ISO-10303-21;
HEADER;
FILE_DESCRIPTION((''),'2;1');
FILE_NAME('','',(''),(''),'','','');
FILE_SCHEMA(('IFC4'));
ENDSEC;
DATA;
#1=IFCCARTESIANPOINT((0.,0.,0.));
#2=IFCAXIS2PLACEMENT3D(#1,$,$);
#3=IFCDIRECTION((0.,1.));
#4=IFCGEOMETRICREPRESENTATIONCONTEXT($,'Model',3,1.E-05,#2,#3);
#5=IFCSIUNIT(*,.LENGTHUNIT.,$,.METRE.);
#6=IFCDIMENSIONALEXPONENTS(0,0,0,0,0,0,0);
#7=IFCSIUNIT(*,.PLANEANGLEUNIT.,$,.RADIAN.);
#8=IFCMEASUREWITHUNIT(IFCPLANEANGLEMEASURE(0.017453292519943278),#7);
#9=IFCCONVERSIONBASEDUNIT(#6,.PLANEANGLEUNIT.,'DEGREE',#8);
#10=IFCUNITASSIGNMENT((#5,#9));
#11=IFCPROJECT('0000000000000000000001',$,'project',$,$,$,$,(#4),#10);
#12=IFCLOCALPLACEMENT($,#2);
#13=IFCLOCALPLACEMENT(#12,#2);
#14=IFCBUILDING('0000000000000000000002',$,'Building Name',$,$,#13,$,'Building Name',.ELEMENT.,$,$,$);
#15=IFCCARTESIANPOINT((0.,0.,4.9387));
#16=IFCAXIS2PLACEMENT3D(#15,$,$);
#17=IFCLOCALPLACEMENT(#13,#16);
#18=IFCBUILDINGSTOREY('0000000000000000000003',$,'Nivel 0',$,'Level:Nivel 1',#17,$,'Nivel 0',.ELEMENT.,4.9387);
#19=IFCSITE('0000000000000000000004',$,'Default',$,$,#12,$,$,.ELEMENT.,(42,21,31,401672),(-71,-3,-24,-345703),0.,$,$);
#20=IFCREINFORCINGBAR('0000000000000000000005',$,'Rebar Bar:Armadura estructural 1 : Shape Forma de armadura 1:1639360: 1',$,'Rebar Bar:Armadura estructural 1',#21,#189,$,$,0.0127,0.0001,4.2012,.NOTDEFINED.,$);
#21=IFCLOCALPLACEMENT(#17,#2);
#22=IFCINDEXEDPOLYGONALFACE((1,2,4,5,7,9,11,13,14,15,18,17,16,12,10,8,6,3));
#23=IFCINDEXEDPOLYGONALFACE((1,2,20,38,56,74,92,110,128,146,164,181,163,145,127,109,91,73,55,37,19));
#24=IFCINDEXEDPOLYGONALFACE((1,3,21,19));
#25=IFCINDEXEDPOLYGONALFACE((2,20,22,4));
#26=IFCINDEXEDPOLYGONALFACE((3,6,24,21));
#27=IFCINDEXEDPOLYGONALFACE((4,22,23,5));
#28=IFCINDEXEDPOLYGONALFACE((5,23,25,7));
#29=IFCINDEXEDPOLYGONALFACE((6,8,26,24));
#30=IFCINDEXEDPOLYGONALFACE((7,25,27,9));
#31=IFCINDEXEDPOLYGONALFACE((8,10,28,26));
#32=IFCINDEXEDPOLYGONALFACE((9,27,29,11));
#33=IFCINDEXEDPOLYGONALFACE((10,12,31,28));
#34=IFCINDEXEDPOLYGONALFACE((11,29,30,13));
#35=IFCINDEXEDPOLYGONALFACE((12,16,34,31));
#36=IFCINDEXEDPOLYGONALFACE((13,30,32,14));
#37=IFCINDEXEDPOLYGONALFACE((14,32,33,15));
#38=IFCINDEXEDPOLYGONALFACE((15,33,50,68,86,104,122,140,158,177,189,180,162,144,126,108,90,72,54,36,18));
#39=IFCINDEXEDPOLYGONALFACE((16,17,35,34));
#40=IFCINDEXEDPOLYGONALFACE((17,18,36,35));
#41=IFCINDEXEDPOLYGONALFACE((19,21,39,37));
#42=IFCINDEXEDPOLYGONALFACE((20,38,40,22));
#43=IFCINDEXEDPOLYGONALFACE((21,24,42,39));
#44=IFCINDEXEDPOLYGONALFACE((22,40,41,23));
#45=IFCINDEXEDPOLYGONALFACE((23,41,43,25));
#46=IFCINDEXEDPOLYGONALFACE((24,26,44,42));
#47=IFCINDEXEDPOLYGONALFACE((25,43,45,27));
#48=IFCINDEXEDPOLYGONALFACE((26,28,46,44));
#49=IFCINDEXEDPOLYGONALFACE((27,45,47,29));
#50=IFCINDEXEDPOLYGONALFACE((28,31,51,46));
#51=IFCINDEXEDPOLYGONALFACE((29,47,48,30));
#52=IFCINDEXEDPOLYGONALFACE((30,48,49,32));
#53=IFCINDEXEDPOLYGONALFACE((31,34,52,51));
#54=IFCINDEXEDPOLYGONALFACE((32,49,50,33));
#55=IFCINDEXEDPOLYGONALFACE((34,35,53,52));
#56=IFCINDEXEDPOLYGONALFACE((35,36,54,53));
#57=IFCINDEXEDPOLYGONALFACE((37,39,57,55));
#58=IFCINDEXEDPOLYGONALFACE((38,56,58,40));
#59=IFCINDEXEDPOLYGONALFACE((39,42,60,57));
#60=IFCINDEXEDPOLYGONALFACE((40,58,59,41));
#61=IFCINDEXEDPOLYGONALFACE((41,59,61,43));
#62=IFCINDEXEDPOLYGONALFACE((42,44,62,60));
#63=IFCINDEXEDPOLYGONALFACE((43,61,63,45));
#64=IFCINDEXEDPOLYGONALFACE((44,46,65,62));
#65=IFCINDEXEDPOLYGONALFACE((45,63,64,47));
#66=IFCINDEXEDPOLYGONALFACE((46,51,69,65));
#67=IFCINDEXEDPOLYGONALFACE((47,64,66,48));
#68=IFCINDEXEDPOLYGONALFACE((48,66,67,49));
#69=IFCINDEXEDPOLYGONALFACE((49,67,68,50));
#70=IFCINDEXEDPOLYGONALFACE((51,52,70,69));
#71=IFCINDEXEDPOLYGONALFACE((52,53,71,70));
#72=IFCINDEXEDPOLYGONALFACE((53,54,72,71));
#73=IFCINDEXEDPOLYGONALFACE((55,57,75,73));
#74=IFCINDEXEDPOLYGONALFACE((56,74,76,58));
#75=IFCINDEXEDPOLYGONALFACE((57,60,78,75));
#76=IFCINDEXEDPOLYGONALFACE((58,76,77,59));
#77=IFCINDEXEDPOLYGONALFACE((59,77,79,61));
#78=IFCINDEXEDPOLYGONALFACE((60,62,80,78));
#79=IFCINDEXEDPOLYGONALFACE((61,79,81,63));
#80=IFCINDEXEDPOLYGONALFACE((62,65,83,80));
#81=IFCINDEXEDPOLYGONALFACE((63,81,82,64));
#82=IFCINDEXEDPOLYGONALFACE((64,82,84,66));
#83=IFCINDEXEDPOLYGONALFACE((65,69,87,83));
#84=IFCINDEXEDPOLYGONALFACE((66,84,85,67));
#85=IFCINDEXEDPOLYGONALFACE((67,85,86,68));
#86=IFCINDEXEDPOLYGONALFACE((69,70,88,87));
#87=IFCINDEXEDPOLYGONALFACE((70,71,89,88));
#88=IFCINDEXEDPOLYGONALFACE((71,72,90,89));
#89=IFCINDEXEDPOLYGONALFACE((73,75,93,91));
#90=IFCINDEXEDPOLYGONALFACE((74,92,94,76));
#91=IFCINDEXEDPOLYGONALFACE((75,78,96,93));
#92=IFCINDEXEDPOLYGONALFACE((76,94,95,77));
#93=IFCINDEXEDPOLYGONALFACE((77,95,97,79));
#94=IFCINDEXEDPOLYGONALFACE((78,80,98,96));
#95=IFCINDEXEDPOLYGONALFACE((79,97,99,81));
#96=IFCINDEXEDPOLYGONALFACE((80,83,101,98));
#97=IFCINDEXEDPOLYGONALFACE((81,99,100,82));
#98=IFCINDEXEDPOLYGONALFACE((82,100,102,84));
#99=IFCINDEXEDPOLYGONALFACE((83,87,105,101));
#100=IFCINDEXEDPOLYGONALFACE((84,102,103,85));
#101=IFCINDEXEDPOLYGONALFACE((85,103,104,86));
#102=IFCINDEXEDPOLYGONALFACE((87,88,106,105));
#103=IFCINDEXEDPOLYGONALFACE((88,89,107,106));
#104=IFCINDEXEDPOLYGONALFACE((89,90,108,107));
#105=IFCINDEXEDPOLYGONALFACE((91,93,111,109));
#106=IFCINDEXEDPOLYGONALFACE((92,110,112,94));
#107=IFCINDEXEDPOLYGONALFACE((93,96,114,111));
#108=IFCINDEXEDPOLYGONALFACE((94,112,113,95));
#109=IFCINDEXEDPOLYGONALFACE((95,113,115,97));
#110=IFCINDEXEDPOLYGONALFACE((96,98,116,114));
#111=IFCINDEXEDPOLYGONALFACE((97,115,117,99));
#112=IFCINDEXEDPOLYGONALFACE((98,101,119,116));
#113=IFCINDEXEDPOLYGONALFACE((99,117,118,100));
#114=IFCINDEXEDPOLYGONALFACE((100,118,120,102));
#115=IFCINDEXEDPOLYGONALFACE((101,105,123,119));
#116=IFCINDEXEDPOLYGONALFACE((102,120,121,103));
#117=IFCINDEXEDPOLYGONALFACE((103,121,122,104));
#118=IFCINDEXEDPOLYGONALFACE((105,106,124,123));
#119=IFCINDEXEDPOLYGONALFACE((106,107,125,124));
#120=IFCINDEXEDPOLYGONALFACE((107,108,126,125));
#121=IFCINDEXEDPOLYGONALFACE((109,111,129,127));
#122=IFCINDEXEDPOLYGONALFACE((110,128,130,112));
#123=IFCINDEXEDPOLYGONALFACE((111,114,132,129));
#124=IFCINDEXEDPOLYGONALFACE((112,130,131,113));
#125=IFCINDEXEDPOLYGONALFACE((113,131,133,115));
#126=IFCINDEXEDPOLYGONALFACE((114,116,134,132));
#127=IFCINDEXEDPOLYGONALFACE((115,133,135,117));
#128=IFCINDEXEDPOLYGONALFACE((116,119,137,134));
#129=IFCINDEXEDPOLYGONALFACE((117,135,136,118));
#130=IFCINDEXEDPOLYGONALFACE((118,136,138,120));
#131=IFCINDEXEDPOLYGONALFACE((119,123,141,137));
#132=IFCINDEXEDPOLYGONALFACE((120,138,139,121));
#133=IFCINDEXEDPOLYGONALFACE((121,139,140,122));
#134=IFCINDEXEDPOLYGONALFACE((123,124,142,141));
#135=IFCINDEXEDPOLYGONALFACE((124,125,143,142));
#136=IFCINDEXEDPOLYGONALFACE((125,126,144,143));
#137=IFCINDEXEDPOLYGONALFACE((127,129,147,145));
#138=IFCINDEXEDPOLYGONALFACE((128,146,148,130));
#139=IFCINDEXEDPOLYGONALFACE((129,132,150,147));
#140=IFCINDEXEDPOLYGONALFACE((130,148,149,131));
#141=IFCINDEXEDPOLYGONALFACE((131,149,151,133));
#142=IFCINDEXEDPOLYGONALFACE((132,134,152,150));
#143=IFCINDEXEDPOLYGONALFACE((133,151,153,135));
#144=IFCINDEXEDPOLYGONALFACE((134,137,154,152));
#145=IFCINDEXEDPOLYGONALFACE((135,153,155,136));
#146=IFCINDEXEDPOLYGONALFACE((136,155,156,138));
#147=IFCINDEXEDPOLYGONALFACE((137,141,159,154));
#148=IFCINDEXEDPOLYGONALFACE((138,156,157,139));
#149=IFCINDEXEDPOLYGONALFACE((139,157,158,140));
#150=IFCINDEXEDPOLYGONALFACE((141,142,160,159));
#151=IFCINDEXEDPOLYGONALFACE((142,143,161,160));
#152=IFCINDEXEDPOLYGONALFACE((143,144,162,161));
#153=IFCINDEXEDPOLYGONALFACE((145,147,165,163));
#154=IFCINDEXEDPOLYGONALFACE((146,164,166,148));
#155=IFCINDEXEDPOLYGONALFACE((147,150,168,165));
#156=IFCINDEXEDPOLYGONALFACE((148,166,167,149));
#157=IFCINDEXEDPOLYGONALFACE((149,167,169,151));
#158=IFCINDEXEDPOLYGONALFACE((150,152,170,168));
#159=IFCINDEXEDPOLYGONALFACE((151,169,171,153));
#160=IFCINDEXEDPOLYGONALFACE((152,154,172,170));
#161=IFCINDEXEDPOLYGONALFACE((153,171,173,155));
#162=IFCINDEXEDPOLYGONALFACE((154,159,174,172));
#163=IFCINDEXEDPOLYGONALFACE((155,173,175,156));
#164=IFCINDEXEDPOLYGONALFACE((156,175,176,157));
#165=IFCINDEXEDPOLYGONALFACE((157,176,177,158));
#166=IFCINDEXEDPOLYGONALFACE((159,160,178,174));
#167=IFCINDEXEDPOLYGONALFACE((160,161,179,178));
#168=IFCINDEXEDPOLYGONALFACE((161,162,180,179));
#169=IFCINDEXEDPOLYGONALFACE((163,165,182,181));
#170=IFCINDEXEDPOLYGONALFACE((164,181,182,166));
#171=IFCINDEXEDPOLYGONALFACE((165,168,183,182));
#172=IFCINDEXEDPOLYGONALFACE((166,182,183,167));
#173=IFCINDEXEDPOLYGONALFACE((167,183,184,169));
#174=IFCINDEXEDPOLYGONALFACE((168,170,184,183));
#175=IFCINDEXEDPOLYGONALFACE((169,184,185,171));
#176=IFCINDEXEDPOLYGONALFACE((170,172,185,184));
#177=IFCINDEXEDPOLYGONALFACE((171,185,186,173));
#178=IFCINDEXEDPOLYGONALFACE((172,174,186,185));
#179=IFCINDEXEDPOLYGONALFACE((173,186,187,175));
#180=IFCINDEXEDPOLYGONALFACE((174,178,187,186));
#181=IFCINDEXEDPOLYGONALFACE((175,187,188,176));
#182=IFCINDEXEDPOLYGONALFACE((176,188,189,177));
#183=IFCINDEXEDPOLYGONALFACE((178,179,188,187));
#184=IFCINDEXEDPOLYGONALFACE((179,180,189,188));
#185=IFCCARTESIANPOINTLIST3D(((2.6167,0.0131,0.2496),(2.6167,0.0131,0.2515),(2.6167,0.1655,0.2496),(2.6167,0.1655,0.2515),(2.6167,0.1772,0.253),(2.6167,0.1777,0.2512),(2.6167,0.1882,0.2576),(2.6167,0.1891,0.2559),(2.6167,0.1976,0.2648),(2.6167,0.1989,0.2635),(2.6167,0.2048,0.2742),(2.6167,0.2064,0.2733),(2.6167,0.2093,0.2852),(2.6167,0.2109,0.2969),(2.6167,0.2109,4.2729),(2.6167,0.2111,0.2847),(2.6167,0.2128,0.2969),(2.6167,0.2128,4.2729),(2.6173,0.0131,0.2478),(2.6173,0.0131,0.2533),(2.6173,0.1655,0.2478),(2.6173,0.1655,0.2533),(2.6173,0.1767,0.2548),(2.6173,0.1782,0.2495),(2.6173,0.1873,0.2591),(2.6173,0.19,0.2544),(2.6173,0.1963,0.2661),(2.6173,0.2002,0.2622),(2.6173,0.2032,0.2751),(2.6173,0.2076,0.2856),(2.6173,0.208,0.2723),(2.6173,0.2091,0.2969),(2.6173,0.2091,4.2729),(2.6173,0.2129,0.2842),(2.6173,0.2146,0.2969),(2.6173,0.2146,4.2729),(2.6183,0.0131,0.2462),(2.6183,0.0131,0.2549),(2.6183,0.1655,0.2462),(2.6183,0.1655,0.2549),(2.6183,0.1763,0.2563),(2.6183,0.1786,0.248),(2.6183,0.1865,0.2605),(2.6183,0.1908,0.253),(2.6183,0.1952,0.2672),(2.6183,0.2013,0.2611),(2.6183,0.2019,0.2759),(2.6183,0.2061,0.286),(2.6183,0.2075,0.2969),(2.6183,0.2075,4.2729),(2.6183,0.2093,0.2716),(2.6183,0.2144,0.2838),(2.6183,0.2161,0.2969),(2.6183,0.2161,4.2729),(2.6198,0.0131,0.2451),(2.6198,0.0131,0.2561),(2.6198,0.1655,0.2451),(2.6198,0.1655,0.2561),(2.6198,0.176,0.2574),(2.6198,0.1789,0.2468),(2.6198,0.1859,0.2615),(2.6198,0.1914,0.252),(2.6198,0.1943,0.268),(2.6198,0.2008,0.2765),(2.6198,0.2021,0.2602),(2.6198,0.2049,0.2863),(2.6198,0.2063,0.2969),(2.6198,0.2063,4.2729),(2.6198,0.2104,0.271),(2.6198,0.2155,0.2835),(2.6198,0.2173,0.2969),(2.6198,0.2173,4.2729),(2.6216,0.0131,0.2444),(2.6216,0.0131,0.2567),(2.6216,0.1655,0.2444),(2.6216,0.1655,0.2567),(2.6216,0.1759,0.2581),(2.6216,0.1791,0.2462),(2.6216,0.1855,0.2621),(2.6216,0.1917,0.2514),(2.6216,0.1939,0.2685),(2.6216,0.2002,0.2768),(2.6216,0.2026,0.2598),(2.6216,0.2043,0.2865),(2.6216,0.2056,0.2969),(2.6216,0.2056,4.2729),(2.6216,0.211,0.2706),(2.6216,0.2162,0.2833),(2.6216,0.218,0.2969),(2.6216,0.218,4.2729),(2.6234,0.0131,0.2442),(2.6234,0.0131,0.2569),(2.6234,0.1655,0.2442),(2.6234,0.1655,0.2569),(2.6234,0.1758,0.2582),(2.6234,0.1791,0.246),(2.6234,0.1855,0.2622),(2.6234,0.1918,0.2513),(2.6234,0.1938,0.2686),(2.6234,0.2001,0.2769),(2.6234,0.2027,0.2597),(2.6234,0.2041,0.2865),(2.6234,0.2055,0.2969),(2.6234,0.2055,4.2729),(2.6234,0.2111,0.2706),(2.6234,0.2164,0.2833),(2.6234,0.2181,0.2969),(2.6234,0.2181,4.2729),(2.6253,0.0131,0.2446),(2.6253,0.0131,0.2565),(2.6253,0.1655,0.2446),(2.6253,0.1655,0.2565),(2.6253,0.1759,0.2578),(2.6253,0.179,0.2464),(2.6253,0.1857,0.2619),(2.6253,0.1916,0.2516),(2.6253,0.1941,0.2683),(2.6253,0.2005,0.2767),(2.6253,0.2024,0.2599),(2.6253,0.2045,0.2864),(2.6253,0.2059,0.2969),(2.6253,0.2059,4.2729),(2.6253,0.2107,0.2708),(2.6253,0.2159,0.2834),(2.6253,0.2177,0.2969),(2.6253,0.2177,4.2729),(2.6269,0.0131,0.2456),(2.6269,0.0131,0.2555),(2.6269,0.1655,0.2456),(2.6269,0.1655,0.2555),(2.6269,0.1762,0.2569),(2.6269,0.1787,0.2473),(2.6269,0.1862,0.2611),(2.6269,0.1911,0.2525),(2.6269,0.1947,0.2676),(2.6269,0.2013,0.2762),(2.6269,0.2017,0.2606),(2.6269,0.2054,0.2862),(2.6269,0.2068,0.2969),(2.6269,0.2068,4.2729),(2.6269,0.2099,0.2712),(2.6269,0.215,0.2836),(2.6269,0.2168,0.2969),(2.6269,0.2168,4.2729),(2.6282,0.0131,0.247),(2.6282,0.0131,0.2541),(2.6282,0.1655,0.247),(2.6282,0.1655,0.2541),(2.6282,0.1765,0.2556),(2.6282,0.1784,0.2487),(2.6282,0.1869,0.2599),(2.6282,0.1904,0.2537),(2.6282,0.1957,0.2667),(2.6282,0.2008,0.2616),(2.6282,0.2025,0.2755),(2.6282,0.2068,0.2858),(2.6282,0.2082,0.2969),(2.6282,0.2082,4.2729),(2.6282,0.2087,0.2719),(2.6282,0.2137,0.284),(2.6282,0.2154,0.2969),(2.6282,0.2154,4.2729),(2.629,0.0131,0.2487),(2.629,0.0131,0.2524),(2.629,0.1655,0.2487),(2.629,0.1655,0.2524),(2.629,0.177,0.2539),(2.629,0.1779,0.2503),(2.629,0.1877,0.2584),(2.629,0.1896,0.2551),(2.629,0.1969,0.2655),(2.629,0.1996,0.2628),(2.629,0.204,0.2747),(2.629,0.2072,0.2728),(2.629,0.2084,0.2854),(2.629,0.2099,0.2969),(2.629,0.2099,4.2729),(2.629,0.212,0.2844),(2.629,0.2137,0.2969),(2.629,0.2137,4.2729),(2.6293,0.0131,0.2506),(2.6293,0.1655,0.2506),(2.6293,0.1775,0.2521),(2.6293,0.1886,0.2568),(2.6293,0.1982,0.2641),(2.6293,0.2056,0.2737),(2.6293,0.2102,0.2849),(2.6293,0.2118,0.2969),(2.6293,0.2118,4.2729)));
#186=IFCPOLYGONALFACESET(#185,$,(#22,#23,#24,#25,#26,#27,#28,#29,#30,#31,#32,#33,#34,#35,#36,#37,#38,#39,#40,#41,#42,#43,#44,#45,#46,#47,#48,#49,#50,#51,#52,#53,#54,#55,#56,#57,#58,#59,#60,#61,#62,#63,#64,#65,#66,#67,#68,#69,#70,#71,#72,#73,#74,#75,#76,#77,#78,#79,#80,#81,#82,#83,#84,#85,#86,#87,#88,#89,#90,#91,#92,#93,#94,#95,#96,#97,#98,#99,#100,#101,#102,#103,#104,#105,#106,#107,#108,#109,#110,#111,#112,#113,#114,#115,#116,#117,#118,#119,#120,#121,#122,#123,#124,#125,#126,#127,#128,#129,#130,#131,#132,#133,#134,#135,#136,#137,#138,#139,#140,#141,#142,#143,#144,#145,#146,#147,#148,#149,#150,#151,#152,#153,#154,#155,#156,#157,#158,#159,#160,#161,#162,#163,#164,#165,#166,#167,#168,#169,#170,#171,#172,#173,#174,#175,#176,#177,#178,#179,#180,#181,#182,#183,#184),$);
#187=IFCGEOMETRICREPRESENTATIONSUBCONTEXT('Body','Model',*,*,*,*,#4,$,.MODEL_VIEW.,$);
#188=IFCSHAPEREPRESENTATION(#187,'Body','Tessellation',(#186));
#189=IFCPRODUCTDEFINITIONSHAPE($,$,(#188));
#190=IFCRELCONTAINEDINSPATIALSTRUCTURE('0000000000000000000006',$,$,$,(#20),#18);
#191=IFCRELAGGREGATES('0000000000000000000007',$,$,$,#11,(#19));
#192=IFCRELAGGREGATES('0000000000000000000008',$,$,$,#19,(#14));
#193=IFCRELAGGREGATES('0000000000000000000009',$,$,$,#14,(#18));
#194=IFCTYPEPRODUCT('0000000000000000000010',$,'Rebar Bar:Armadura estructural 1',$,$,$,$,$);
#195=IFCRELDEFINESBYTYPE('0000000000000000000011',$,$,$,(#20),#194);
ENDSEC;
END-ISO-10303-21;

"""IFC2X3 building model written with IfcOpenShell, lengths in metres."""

from ifc_helpers import new_model, entity, si_unit, converted_unit, direction, frame, origin, place, context, subcontext, project, spatial, type_object, element, save


model = new_model("IFC2X3")

# Units and contexts
model_context = context("Model", 3, precision=1e-05, world=origin(), true_north=direction((0.0, 1.0)))
body_context = subcontext(model_context, "Body", "Model", "MODEL_VIEW")
ifc_project = project(units=[si_unit("LENGTHUNIT", "METRE"), converted_unit("PLANEANGLEUNIT", "DEGREE", entity("IfcPlaneAngleMeasure", 0.017453292519943278), si_unit("PLANEANGLEUNIT", "RADIAN"), dimensions=[0, 0, 0, 0, 0, 0, 0])], contexts=[model_context])

# Site, building, storey
site_placement = place(None, origin())
site = spatial("IfcSite", under=ifc_project, at=site_placement, Name="Default", CompositionType="ELEMENT", RefLatitude=(42, 21, 31, 401672), RefLongitude=(-71, -3, -24, -345703), RefElevation=0.0)
building_placement = place(site_placement, origin())
building = spatial("IfcBuilding", under=site, at=building_placement, Name="Building Name", LongName="Building Name", CompositionType="ELEMENT")
storey_placement = place(building_placement, frame((0.0, 0.0, 4.9387)))
storey = spatial("IfcBuildingStorey", under=building, at=storey_placement, Name="Nivel 0", ObjectType="Level:Nivel 1", LongName="Nivel 0", CompositionType="ELEMENT", Elevation=4.9387)

# Reinforcing bar
type_product = type_object("IfcTypeProduct", Name="Rebar Bar:Armadura estructural 1")
reinforcing_bar_1_placement = place(storey_placement, origin())
element("IfcReinforcingBar", 1, at=reinforcing_bar_1_placement, inside=storey, type_object=type_product, Name="Rebar Bar:Armadura estructural 1 : Shape Forma de armadura 1:1639360: 1", ObjectType="Rebar Bar:Armadura estructural 1", BarLength=4.2012, BarRole="NOTDEFINED", CrossSectionArea=0.0001, NominalDiameter=0.0127, context=body_context, shape_type="AdvancedSweptSolid", body=[
    entity("IfcSweptDiskSolid", entity("IfcCompositeCurve", [entity("IfcCompositeCurveSegment", "CONTINUOUS", True, entity("IfcPolyline", [entity("IfcCartesianPoint", [2.623, 0.0131, 0.2506]), entity("IfcCartesianPoint", [2.623, 0.1655, 0.2506])])), entity("IfcCompositeCurveSegment", "CONTINUOUS", True, entity("IfcTrimmedCurve", entity("IfcCircle", entity("IfcAxis2Placement3D", entity("IfcCartesianPoint", [2.623, 0.1655, 0.2969]), entity("IfcDirection", [1.0, 0.0, 0.0]), entity("IfcDirection", [0.0, 1.0, 0.0])), 0.0464), [entity("IfcParameterValue", 270.0)], [entity("IfcParameterValue", 360.0)], True, "PARAMETER")), entity("IfcCompositeCurveSegment", "CONTINUOUS", True, entity("IfcPolyline", [entity("IfcCartesianPoint", [2.623, 0.2118, 0.2969]), entity("IfcCartesianPoint", [2.623, 0.2118, 4.2729])]))], False), 0.0063, None, 0.0, 92.0),
])

save(model, "model.ifc")
